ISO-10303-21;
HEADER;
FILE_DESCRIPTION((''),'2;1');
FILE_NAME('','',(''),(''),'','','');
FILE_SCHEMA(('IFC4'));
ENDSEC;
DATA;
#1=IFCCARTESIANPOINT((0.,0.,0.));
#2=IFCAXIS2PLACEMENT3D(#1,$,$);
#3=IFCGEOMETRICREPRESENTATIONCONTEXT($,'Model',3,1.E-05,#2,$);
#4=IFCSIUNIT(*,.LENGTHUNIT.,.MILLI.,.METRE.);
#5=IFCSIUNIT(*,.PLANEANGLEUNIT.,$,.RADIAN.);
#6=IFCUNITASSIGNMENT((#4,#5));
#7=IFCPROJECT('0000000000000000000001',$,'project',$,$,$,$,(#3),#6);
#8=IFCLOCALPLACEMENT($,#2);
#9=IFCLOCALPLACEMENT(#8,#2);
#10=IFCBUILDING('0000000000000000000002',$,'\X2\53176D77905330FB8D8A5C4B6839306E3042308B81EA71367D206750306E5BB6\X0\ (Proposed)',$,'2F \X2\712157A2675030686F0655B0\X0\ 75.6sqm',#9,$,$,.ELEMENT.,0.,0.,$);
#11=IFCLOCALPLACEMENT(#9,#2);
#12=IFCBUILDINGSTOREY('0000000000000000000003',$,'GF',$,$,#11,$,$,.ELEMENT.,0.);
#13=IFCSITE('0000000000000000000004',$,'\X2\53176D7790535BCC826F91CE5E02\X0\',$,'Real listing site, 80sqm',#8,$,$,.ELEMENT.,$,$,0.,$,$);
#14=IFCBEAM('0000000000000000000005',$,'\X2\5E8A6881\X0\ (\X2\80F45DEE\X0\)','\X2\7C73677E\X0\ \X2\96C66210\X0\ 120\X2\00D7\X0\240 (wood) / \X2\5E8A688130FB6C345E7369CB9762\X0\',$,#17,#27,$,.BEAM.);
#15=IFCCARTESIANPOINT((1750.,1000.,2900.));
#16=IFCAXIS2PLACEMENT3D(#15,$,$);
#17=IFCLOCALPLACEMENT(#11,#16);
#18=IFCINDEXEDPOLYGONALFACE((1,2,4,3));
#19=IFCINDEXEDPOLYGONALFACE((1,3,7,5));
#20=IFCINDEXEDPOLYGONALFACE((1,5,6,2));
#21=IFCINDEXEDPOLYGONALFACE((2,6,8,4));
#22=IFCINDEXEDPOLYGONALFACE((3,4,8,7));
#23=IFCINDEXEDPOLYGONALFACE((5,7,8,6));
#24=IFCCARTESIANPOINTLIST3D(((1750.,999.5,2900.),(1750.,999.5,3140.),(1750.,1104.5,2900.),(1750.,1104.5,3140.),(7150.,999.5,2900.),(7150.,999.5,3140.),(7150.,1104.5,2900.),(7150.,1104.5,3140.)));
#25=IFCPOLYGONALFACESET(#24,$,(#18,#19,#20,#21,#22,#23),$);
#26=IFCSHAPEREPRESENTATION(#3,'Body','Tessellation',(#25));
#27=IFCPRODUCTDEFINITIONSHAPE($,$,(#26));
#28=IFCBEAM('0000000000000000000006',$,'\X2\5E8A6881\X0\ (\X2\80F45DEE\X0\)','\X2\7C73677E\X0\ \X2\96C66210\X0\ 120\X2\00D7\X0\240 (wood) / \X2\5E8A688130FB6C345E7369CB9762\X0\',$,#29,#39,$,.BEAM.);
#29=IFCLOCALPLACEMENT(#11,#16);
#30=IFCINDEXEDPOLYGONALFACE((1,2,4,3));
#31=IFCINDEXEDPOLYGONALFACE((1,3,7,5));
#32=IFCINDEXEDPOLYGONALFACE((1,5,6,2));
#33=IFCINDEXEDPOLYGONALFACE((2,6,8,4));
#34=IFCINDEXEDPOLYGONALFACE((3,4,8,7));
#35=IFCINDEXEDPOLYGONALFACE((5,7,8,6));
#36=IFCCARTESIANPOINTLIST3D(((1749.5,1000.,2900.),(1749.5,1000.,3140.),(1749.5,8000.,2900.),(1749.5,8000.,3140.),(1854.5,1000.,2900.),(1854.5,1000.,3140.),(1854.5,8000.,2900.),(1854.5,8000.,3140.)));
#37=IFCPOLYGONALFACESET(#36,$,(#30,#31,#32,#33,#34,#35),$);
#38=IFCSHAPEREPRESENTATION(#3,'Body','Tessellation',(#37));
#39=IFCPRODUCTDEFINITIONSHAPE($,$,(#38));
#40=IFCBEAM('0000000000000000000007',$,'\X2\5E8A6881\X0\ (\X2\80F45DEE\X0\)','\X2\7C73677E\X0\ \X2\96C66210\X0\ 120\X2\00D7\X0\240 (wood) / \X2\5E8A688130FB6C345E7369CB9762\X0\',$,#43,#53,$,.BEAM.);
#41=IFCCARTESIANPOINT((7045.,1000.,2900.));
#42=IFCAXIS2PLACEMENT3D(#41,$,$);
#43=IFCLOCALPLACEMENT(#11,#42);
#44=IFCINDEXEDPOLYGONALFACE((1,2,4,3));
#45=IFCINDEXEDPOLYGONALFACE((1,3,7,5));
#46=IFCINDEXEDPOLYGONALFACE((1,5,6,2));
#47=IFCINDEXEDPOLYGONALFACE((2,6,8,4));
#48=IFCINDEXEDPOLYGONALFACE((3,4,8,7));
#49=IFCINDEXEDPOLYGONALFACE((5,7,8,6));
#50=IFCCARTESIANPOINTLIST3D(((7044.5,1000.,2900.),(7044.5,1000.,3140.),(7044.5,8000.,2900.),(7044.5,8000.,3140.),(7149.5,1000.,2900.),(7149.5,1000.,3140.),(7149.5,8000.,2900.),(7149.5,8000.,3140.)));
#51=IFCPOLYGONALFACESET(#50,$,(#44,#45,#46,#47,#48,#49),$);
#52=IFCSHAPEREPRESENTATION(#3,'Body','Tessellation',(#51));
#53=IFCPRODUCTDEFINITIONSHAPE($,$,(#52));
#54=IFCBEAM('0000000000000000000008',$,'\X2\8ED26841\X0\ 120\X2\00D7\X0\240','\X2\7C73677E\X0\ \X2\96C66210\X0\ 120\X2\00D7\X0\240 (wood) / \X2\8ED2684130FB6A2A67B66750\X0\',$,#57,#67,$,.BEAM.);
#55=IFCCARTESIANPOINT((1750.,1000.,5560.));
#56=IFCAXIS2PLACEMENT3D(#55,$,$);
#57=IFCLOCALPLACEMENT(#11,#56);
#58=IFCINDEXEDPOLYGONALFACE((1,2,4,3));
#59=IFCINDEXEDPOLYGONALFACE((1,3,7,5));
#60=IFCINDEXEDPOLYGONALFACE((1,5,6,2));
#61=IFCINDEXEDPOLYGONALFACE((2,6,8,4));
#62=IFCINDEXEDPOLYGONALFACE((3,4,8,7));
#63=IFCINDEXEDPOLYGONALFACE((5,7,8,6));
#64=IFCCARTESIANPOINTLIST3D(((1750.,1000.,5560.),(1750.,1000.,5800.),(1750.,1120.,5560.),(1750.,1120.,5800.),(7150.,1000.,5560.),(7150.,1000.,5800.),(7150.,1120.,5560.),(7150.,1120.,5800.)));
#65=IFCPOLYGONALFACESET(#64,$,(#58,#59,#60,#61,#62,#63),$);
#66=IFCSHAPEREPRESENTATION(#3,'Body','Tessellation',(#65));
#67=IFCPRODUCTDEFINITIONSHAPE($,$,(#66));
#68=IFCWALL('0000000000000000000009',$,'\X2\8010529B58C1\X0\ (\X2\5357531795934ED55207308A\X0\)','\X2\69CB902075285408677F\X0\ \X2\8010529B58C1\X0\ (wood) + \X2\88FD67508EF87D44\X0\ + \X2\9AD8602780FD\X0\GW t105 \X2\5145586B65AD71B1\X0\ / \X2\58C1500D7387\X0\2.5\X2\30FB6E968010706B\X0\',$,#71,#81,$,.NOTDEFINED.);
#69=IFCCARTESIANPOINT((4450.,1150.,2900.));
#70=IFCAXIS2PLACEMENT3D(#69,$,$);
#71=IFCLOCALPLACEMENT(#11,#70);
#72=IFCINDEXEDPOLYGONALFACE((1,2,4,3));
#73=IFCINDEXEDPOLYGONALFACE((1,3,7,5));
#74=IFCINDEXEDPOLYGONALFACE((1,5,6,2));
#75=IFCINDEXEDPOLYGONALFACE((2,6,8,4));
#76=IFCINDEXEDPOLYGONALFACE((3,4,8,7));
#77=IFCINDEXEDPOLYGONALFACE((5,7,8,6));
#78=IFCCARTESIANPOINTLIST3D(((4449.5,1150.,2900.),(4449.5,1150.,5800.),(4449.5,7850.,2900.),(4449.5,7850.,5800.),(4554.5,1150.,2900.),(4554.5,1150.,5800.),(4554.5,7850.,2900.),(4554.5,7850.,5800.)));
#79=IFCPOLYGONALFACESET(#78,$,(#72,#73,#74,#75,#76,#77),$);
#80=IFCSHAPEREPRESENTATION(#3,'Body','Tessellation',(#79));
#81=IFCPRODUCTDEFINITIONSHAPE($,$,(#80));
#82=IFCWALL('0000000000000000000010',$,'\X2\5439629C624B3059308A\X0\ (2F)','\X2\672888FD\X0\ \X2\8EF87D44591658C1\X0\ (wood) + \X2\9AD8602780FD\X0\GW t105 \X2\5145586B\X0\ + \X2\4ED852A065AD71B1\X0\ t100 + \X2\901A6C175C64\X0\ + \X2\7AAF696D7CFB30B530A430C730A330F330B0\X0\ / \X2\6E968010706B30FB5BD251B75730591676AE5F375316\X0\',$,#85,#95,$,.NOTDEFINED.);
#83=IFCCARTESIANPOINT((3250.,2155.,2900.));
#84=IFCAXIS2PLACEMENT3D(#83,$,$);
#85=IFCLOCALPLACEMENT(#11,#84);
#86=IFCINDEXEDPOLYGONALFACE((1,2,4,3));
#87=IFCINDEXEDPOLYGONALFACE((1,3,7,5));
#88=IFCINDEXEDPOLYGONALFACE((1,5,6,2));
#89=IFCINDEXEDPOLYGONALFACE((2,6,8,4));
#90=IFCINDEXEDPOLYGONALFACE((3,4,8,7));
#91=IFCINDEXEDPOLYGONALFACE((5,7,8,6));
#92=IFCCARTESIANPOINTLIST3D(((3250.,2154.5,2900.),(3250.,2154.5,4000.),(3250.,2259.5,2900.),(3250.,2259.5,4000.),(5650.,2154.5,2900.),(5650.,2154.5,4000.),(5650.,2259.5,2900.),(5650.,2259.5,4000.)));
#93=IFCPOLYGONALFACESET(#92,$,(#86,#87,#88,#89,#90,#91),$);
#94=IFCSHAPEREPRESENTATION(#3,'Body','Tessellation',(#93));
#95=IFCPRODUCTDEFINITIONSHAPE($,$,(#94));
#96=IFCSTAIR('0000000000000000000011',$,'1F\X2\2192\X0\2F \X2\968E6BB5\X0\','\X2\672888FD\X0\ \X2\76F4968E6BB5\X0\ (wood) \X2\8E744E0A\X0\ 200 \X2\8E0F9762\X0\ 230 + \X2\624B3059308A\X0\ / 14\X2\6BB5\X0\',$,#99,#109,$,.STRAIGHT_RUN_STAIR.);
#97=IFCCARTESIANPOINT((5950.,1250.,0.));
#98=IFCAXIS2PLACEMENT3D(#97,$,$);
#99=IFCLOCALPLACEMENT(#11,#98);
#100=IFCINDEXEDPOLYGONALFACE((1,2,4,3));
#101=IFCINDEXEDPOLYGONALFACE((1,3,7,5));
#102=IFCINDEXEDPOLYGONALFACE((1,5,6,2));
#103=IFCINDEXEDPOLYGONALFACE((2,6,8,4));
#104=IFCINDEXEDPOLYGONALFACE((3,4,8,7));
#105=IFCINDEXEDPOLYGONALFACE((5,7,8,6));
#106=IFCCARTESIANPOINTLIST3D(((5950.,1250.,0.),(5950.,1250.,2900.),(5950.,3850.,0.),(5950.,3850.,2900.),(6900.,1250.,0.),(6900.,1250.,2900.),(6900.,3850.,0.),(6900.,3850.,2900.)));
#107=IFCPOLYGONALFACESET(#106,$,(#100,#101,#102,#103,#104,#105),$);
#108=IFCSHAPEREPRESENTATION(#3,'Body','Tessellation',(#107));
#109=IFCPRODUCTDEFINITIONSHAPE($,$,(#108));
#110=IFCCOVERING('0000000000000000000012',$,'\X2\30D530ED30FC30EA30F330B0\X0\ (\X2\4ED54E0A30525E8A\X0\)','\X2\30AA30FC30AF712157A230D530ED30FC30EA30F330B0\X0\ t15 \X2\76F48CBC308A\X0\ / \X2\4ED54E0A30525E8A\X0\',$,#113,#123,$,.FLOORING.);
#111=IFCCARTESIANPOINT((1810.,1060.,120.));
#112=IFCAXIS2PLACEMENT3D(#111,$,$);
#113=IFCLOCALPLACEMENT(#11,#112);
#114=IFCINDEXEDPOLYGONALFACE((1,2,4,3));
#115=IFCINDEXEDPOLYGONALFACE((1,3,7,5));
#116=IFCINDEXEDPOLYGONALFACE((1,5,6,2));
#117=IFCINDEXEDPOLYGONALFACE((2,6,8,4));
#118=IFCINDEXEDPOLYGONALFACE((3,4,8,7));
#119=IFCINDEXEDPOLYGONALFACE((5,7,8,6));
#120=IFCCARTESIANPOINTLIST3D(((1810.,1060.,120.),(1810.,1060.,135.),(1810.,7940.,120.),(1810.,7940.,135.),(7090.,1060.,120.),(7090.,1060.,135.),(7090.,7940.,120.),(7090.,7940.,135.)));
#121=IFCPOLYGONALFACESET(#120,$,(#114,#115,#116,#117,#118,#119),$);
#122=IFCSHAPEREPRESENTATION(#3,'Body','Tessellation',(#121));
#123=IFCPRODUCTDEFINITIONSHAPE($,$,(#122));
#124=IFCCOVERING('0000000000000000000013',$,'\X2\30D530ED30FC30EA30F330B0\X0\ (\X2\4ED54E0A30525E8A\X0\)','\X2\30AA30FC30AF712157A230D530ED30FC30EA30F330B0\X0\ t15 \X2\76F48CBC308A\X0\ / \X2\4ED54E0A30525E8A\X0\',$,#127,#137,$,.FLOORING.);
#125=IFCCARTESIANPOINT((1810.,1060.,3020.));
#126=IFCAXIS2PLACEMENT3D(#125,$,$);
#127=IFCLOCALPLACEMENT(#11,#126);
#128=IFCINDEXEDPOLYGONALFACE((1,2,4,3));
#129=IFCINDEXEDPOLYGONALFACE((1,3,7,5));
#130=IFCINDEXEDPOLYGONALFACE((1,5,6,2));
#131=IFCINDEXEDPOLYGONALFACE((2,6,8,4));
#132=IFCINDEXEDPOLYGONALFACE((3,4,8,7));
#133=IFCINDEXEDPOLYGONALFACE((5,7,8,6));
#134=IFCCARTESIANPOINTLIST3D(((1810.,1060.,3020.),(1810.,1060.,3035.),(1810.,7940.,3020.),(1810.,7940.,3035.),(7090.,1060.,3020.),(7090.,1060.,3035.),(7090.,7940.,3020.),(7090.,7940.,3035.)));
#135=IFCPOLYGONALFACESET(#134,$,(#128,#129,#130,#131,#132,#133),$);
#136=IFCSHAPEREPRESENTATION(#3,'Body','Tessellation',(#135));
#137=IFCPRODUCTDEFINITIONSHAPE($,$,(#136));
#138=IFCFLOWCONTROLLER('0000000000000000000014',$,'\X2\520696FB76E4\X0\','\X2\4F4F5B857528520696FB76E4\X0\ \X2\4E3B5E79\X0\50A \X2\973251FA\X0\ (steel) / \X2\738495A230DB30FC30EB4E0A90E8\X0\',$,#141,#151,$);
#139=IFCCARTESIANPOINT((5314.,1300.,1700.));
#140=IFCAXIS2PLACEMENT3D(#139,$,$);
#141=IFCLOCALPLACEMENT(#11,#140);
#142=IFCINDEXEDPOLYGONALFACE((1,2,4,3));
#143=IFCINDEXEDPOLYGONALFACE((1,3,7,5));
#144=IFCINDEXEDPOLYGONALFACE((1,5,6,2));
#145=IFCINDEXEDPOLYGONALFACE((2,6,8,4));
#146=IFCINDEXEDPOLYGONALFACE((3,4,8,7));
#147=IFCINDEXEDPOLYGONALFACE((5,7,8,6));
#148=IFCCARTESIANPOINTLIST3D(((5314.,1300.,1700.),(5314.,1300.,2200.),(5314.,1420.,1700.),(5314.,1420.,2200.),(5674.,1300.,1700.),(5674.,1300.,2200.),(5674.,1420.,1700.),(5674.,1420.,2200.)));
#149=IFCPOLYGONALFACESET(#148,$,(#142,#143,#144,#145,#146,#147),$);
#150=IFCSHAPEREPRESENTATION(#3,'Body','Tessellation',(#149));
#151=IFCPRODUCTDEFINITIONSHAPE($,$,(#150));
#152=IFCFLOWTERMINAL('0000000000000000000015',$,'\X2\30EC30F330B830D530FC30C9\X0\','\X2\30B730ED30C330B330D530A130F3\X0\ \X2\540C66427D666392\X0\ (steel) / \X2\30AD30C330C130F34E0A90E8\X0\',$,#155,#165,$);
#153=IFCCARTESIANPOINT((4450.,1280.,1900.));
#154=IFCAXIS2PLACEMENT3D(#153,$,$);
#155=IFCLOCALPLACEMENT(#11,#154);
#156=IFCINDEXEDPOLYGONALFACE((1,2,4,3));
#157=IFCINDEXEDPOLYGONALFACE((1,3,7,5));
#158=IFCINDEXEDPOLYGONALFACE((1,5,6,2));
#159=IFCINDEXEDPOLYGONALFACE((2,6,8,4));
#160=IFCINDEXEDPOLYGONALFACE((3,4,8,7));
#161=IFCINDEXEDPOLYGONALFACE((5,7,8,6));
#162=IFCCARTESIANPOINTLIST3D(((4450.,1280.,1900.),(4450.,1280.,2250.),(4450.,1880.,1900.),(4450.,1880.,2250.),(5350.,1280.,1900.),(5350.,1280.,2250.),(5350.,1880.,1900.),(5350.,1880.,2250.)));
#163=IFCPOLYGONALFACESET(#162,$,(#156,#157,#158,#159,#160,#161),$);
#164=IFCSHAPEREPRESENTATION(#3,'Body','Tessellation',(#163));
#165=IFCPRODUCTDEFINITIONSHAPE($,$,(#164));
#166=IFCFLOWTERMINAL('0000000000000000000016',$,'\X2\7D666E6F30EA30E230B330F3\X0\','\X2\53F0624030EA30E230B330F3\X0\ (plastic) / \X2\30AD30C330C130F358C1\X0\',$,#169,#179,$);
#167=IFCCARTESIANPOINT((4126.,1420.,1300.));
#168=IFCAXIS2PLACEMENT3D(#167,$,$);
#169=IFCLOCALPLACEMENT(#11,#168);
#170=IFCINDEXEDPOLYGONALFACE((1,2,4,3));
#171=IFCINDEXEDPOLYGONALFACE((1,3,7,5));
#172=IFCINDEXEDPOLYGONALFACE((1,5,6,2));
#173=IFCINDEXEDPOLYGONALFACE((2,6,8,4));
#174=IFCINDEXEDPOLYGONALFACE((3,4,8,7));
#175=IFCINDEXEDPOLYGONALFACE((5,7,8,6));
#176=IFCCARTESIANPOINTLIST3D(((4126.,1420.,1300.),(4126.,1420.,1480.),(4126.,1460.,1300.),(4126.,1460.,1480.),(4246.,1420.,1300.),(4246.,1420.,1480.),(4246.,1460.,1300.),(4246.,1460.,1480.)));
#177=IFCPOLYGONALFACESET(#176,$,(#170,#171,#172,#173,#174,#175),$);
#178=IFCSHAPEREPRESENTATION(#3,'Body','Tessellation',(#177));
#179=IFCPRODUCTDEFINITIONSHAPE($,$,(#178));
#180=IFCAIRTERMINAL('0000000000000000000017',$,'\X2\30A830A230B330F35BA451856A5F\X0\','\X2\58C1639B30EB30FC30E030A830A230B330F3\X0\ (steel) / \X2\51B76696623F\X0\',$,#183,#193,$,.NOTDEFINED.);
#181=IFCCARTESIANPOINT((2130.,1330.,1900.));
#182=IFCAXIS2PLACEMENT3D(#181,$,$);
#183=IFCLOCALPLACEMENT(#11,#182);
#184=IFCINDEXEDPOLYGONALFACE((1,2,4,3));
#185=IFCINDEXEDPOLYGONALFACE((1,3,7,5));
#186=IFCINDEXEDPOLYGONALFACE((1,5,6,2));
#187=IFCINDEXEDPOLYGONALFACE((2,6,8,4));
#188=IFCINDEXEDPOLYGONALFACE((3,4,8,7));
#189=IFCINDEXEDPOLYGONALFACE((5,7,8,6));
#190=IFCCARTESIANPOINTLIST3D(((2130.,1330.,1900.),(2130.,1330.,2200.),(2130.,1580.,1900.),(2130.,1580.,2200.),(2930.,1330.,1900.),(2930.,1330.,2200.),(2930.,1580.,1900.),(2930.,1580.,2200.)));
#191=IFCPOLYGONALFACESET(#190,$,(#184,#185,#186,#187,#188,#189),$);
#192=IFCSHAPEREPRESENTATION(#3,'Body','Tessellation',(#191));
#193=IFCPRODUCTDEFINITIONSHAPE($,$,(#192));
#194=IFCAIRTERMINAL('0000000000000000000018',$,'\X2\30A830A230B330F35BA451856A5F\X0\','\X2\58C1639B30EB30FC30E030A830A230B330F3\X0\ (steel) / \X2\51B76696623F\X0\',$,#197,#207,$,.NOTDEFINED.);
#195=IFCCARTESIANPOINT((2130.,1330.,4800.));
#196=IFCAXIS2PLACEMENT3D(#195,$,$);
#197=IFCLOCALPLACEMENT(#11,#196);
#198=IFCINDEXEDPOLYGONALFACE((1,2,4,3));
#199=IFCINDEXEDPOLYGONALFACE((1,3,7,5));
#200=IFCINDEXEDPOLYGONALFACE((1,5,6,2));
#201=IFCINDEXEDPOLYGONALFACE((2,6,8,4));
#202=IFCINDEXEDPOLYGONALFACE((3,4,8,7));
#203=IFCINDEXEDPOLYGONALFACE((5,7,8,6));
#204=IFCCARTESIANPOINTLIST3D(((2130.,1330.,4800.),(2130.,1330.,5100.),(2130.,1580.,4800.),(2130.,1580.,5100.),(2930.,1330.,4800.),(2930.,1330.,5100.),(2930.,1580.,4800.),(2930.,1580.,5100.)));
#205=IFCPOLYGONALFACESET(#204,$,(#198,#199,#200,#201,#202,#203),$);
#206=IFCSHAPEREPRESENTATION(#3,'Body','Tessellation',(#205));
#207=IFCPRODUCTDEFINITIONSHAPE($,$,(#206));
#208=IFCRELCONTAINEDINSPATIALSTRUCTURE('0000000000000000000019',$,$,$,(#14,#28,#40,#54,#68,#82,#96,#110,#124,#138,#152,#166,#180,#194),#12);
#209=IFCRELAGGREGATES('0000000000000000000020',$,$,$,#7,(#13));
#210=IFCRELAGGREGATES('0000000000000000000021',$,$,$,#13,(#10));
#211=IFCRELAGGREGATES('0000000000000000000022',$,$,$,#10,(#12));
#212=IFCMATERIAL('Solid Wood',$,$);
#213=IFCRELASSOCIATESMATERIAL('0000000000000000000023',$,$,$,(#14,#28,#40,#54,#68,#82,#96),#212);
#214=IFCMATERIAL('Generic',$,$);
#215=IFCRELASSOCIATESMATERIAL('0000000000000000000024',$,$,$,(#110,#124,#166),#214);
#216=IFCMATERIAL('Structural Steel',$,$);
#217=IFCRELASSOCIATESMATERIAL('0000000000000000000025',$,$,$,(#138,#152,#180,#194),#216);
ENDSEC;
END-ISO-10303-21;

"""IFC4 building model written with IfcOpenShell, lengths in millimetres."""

from ifc_helpers import new_model, si_unit, frame, frame_2d, origin, place, context, project, spatial, rectangle, extrude, material, element, save


model = new_model("IFC4")

# Units and contexts
model_context = context("Model", 3, precision=1e-05, world=origin())
ifc_project = project(units=[si_unit("LENGTHUNIT", "METRE", prefix="MILLI"), si_unit("PLANEANGLEUNIT", "RADIAN")], contexts=[model_context])

# Site, building, storey
site_placement = place(None, origin())
site = spatial("IfcSite", under=ifc_project, at=site_placement, Name="北海道富良野市", ObjectType="Real listing site, 80sqm", CompositionType="ELEMENT", RefElevation=0.0)
building_placement = place(site_placement, origin())
building = spatial("IfcBuilding", under=site, at=building_placement, Name="北海道・越屋根のある自然素材の家 (Proposed)", ObjectType="2F 無垢材と漆喰 75.6sqm", CompositionType="ELEMENT", ElevationOfRefHeight=0.0, ElevationOfTerrain=0.0)
storey_placement = place(building_placement, origin())
storey = spatial("IfcBuildingStorey", under=building, at=storey_placement, Name="GF", CompositionType="ELEMENT", Elevation=0.0)

# Shared definitions
ifc_material_1 = material(Name="Solid Wood")

# Beams
beam_1_placement = place(storey_placement, frame((1750.0, 1000.0, 2900.0)))
element("IfcBeam", 1, at=beam_1_placement, inside=storey, material=ifc_material_1, Name="床梁 (胴差)", Description="米松 集成 120×240 (wood) / 床梁・水平構面", PredefinedType="BEAM", context=model_context, shape_type="SweptSolid", body=[
    extrude(rectangle(XDim=5400.0, YDim=105.0, at=frame_2d((2700.0, 52.0))), frame((1750.0, 1000.0, 2900.0)), (0.0, 0.0, 1.0), 240.0),
])
beam_2_placement = place(storey_placement, frame((1750.0, 1000.0, 2900.0)))
element("IfcBeam", 2, at=beam_2_placement, inside=storey, material=ifc_material_1, Name="床梁 (胴差)", Description="米松 集成 120×240 (wood) / 床梁・水平構面", PredefinedType="BEAM", context=model_context, shape_type="SweptSolid", body=[
    extrude(rectangle(XDim=105.0, YDim=7000.0, at=frame_2d((52.0, 3500.0))), frame((1750.0, 1000.0, 2900.0)), (0.0, 0.0, 1.0), 240.0),
])
beam_3_placement = place(storey_placement, frame((7045.0, 1000.0, 2900.0)))
element("IfcBeam", 3, at=beam_3_placement, inside=storey, material=ifc_material_1, Name="床梁 (胴差)", Description="米松 集成 120×240 (wood) / 床梁・水平構面", PredefinedType="BEAM", context=model_context, shape_type="SweptSolid", body=[
    extrude(rectangle(XDim=105.0, YDim=7000.0, at=frame_2d((52.0, 3500.0))), frame((7045.0, 1000.0, 2900.0)), (0.0, 0.0, 1.0), 240.0),
])
beam_4_placement = place(storey_placement, frame((1750.0, 1000.0, 5560.0)))
element("IfcBeam", 4, at=beam_4_placement, inside=storey, material=ifc_material_1, Name="軒桁 120×240", Description="米松 集成 120×240 (wood) / 軒桁・横架材", PredefinedType="BEAM", context=model_context, shape_type="SweptSolid", body=[
    extrude(rectangle(XDim=5400.0, YDim=120.0, at=frame_2d((2700.0, 60.0))), frame((1750.0, 1000.0, 5560.0)), (0.0, 0.0, 1.0), 240.0),
])

# Walls
wall_1_placement = place(storey_placement, frame((4450.0, 1150.0, 2900.0)))
element("IfcWall", 5, at=wall_1_placement, inside=storey, material=ifc_material_1, Name="耐力壁 (南北間仕切り)", Description="構造用合板 耐力壁 (wood) + 製材軸組 + 高性能GW t105 充填断熱 / 壁倍率2.5・準耐火", PredefinedType="NOTDEFINED", context=model_context, shape_type="SweptSolid", body=[
    extrude(rectangle(XDim=105.0, YDim=6700.0, at=frame_2d((52.0, 3350.0))), frame((4450.0, 1150.0, 2900.0)), (0.0, 0.0, 1.0), 2900.0),
])
wall_2_placement = place(storey_placement, frame((3250.0, 2155.0, 2900.0)))
element("IfcWall", 6, at=wall_2_placement, inside=storey, material=ifc_material_1, Name="吹抜手すり (2F)", Description="木製 軸組外壁 (wood) + 高性能GW t105 充填 + 付加断熱 t100 + 通気層 + 窯業系サイディング / 準耐火・寒冷地外皮強化", PredefinedType="NOTDEFINED", context=model_context, shape_type="SweptSolid", body=[
    extrude(rectangle(XDim=2400.0, YDim=105.0, at=frame_2d((1200.0, 52.0))), frame((3250.0, 2155.0, 2900.0)), (0.0, 0.0, 1.0), 1100.0),
])

# Stair
stair_placement = place(storey_placement, frame((5950.0, 1250.0, 0.0)))
element("IfcStair", 7, at=stair_placement, inside=storey, material=ifc_material_1, Name="1F→2F 階段", Description="木製 直階段 (wood) 蹴上 200 踏面 230 + 手すり / 14段", PredefinedType="STRAIGHT_RUN_STAIR", context=model_context, shape_type="SweptSolid", body=[
    extrude(rectangle(XDim=950.0, YDim=2600.0, at=frame_2d((475.0, 1300.0))), frame((5950.0, 1250.0, 0.0)), (0.0, 0.0, 1.0), 2900.0),
])

# Coverings
ifc_material_2 = material(Name="Generic")
covering_1_placement = place(storey_placement, frame((1810.0, 1060.0, 120.0)))
element("IfcCovering", 8, at=covering_1_placement, inside=storey, material=ifc_material_2, Name="フローリング (仕上げ床)", Description="オーク無垢フローリング t15 直貼り / 仕上げ床", PredefinedType="FLOORING", context=model_context, shape_type="SweptSolid", body=[
    extrude(rectangle(XDim=5280.0, YDim=6880.0, at=frame_2d((2640.0, 3440.0))), frame((1810.0, 1060.0, 120.0)), (0.0, 0.0, 1.0), 15.0),
])
covering_2_placement = place(storey_placement, frame((1810.0, 1060.0, 3020.0)))
element("IfcCovering", 9, at=covering_2_placement, inside=storey, material=ifc_material_2, Name="フローリング (仕上げ床)", Description="オーク無垢フローリング t15 直貼り / 仕上げ床", PredefinedType="FLOORING", context=model_context, shape_type="SweptSolid", body=[
    extrude(rectangle(XDim=5280.0, YDim=6880.0, at=frame_2d((2640.0, 3440.0))), frame((1810.0, 1060.0, 3020.0)), (0.0, 0.0, 1.0), 15.0),
])

# Flow controller
ifc_material_3 = material(Name="Structural Steel")
flow_controller_placement = place(storey_placement, frame((5314.0, 1300.0, 1700.0)))
element("IfcFlowController", 10, at=flow_controller_placement, inside=storey, material=ifc_material_3, Name="分電盤", Description="住宅用分電盤 主幹50A 露出 (steel) / 玄関ホール上部", context=model_context, shape_type="SweptSolid", body=[
    extrude(rectangle(XDim=360.0, YDim=120.0, at=frame_2d((180.0, 60.0))), frame((5314.0, 1300.0, 1700.0)), (0.0, 0.0, 1.0), 500.0),
])

# Flow terminals
flow_terminal_1_placement = place(storey_placement, frame((4450.0, 1280.0, 1900.0)))
element("IfcFlowTerminal", 11, at=flow_terminal_1_placement, inside=storey, material=ifc_material_3, Name="レンジフード", Description="シロッコファン 同時給排 (steel) / キッチン上部", context=model_context, shape_type="SweptSolid", body=[
    extrude(rectangle(XDim=900.0, YDim=600.0, at=frame_2d((450.0, 300.0))), frame((4450.0, 1280.0, 1900.0)), (0.0, 0.0, 1.0), 350.0),
])
flow_terminal_2_placement = place(storey_placement, frame((4126.0, 1420.0, 1300.0)))
element("IfcFlowTerminal", 12, at=flow_terminal_2_placement, inside=storey, material=ifc_material_2, Name="給湯リモコン", Description="台所リモコン (plastic) / キッチン壁", context=model_context, shape_type="SweptSolid", body=[
    extrude(rectangle(XDim=120.0, YDim=40.0, at=frame_2d((60.0, 20.0))), frame((4126.0, 1420.0, 1300.0)), (0.0, 0.0, 1.0), 180.0),
])

# Air terminals
air_terminal_1_placement = place(storey_placement, frame((2130.0, 1330.0, 1900.0)))
element("IfcAirTerminal", 13, at=air_terminal_1_placement, inside=storey, material=ifc_material_3, Name="エアコン室内機", Description="壁掛ルームエアコン (steel) / 冷暖房", PredefinedType="NOTDEFINED", context=model_context, shape_type="SweptSolid", body=[
    extrude(rectangle(XDim=800.0, YDim=250.0, at=frame_2d((400.0, 125.0))), frame((2130.0, 1330.0, 1900.0)), (0.0, 0.0, 1.0), 300.0),
])
air_terminal_2_placement = place(storey_placement, frame((2130.0, 1330.0, 4800.0)))
element("IfcAirTerminal", 14, at=air_terminal_2_placement, inside=storey, material=ifc_material_3, Name="エアコン室内機", Description="壁掛ルームエアコン (steel) / 冷暖房", PredefinedType="NOTDEFINED", context=model_context, shape_type="SweptSolid", body=[
    extrude(rectangle(XDim=800.0, YDim=250.0, at=frame_2d((400.0, 125.0))), frame((2130.0, 1330.0, 4800.0)), (0.0, 0.0, 1.0), 300.0),
])

save(model, "model.ifc")
